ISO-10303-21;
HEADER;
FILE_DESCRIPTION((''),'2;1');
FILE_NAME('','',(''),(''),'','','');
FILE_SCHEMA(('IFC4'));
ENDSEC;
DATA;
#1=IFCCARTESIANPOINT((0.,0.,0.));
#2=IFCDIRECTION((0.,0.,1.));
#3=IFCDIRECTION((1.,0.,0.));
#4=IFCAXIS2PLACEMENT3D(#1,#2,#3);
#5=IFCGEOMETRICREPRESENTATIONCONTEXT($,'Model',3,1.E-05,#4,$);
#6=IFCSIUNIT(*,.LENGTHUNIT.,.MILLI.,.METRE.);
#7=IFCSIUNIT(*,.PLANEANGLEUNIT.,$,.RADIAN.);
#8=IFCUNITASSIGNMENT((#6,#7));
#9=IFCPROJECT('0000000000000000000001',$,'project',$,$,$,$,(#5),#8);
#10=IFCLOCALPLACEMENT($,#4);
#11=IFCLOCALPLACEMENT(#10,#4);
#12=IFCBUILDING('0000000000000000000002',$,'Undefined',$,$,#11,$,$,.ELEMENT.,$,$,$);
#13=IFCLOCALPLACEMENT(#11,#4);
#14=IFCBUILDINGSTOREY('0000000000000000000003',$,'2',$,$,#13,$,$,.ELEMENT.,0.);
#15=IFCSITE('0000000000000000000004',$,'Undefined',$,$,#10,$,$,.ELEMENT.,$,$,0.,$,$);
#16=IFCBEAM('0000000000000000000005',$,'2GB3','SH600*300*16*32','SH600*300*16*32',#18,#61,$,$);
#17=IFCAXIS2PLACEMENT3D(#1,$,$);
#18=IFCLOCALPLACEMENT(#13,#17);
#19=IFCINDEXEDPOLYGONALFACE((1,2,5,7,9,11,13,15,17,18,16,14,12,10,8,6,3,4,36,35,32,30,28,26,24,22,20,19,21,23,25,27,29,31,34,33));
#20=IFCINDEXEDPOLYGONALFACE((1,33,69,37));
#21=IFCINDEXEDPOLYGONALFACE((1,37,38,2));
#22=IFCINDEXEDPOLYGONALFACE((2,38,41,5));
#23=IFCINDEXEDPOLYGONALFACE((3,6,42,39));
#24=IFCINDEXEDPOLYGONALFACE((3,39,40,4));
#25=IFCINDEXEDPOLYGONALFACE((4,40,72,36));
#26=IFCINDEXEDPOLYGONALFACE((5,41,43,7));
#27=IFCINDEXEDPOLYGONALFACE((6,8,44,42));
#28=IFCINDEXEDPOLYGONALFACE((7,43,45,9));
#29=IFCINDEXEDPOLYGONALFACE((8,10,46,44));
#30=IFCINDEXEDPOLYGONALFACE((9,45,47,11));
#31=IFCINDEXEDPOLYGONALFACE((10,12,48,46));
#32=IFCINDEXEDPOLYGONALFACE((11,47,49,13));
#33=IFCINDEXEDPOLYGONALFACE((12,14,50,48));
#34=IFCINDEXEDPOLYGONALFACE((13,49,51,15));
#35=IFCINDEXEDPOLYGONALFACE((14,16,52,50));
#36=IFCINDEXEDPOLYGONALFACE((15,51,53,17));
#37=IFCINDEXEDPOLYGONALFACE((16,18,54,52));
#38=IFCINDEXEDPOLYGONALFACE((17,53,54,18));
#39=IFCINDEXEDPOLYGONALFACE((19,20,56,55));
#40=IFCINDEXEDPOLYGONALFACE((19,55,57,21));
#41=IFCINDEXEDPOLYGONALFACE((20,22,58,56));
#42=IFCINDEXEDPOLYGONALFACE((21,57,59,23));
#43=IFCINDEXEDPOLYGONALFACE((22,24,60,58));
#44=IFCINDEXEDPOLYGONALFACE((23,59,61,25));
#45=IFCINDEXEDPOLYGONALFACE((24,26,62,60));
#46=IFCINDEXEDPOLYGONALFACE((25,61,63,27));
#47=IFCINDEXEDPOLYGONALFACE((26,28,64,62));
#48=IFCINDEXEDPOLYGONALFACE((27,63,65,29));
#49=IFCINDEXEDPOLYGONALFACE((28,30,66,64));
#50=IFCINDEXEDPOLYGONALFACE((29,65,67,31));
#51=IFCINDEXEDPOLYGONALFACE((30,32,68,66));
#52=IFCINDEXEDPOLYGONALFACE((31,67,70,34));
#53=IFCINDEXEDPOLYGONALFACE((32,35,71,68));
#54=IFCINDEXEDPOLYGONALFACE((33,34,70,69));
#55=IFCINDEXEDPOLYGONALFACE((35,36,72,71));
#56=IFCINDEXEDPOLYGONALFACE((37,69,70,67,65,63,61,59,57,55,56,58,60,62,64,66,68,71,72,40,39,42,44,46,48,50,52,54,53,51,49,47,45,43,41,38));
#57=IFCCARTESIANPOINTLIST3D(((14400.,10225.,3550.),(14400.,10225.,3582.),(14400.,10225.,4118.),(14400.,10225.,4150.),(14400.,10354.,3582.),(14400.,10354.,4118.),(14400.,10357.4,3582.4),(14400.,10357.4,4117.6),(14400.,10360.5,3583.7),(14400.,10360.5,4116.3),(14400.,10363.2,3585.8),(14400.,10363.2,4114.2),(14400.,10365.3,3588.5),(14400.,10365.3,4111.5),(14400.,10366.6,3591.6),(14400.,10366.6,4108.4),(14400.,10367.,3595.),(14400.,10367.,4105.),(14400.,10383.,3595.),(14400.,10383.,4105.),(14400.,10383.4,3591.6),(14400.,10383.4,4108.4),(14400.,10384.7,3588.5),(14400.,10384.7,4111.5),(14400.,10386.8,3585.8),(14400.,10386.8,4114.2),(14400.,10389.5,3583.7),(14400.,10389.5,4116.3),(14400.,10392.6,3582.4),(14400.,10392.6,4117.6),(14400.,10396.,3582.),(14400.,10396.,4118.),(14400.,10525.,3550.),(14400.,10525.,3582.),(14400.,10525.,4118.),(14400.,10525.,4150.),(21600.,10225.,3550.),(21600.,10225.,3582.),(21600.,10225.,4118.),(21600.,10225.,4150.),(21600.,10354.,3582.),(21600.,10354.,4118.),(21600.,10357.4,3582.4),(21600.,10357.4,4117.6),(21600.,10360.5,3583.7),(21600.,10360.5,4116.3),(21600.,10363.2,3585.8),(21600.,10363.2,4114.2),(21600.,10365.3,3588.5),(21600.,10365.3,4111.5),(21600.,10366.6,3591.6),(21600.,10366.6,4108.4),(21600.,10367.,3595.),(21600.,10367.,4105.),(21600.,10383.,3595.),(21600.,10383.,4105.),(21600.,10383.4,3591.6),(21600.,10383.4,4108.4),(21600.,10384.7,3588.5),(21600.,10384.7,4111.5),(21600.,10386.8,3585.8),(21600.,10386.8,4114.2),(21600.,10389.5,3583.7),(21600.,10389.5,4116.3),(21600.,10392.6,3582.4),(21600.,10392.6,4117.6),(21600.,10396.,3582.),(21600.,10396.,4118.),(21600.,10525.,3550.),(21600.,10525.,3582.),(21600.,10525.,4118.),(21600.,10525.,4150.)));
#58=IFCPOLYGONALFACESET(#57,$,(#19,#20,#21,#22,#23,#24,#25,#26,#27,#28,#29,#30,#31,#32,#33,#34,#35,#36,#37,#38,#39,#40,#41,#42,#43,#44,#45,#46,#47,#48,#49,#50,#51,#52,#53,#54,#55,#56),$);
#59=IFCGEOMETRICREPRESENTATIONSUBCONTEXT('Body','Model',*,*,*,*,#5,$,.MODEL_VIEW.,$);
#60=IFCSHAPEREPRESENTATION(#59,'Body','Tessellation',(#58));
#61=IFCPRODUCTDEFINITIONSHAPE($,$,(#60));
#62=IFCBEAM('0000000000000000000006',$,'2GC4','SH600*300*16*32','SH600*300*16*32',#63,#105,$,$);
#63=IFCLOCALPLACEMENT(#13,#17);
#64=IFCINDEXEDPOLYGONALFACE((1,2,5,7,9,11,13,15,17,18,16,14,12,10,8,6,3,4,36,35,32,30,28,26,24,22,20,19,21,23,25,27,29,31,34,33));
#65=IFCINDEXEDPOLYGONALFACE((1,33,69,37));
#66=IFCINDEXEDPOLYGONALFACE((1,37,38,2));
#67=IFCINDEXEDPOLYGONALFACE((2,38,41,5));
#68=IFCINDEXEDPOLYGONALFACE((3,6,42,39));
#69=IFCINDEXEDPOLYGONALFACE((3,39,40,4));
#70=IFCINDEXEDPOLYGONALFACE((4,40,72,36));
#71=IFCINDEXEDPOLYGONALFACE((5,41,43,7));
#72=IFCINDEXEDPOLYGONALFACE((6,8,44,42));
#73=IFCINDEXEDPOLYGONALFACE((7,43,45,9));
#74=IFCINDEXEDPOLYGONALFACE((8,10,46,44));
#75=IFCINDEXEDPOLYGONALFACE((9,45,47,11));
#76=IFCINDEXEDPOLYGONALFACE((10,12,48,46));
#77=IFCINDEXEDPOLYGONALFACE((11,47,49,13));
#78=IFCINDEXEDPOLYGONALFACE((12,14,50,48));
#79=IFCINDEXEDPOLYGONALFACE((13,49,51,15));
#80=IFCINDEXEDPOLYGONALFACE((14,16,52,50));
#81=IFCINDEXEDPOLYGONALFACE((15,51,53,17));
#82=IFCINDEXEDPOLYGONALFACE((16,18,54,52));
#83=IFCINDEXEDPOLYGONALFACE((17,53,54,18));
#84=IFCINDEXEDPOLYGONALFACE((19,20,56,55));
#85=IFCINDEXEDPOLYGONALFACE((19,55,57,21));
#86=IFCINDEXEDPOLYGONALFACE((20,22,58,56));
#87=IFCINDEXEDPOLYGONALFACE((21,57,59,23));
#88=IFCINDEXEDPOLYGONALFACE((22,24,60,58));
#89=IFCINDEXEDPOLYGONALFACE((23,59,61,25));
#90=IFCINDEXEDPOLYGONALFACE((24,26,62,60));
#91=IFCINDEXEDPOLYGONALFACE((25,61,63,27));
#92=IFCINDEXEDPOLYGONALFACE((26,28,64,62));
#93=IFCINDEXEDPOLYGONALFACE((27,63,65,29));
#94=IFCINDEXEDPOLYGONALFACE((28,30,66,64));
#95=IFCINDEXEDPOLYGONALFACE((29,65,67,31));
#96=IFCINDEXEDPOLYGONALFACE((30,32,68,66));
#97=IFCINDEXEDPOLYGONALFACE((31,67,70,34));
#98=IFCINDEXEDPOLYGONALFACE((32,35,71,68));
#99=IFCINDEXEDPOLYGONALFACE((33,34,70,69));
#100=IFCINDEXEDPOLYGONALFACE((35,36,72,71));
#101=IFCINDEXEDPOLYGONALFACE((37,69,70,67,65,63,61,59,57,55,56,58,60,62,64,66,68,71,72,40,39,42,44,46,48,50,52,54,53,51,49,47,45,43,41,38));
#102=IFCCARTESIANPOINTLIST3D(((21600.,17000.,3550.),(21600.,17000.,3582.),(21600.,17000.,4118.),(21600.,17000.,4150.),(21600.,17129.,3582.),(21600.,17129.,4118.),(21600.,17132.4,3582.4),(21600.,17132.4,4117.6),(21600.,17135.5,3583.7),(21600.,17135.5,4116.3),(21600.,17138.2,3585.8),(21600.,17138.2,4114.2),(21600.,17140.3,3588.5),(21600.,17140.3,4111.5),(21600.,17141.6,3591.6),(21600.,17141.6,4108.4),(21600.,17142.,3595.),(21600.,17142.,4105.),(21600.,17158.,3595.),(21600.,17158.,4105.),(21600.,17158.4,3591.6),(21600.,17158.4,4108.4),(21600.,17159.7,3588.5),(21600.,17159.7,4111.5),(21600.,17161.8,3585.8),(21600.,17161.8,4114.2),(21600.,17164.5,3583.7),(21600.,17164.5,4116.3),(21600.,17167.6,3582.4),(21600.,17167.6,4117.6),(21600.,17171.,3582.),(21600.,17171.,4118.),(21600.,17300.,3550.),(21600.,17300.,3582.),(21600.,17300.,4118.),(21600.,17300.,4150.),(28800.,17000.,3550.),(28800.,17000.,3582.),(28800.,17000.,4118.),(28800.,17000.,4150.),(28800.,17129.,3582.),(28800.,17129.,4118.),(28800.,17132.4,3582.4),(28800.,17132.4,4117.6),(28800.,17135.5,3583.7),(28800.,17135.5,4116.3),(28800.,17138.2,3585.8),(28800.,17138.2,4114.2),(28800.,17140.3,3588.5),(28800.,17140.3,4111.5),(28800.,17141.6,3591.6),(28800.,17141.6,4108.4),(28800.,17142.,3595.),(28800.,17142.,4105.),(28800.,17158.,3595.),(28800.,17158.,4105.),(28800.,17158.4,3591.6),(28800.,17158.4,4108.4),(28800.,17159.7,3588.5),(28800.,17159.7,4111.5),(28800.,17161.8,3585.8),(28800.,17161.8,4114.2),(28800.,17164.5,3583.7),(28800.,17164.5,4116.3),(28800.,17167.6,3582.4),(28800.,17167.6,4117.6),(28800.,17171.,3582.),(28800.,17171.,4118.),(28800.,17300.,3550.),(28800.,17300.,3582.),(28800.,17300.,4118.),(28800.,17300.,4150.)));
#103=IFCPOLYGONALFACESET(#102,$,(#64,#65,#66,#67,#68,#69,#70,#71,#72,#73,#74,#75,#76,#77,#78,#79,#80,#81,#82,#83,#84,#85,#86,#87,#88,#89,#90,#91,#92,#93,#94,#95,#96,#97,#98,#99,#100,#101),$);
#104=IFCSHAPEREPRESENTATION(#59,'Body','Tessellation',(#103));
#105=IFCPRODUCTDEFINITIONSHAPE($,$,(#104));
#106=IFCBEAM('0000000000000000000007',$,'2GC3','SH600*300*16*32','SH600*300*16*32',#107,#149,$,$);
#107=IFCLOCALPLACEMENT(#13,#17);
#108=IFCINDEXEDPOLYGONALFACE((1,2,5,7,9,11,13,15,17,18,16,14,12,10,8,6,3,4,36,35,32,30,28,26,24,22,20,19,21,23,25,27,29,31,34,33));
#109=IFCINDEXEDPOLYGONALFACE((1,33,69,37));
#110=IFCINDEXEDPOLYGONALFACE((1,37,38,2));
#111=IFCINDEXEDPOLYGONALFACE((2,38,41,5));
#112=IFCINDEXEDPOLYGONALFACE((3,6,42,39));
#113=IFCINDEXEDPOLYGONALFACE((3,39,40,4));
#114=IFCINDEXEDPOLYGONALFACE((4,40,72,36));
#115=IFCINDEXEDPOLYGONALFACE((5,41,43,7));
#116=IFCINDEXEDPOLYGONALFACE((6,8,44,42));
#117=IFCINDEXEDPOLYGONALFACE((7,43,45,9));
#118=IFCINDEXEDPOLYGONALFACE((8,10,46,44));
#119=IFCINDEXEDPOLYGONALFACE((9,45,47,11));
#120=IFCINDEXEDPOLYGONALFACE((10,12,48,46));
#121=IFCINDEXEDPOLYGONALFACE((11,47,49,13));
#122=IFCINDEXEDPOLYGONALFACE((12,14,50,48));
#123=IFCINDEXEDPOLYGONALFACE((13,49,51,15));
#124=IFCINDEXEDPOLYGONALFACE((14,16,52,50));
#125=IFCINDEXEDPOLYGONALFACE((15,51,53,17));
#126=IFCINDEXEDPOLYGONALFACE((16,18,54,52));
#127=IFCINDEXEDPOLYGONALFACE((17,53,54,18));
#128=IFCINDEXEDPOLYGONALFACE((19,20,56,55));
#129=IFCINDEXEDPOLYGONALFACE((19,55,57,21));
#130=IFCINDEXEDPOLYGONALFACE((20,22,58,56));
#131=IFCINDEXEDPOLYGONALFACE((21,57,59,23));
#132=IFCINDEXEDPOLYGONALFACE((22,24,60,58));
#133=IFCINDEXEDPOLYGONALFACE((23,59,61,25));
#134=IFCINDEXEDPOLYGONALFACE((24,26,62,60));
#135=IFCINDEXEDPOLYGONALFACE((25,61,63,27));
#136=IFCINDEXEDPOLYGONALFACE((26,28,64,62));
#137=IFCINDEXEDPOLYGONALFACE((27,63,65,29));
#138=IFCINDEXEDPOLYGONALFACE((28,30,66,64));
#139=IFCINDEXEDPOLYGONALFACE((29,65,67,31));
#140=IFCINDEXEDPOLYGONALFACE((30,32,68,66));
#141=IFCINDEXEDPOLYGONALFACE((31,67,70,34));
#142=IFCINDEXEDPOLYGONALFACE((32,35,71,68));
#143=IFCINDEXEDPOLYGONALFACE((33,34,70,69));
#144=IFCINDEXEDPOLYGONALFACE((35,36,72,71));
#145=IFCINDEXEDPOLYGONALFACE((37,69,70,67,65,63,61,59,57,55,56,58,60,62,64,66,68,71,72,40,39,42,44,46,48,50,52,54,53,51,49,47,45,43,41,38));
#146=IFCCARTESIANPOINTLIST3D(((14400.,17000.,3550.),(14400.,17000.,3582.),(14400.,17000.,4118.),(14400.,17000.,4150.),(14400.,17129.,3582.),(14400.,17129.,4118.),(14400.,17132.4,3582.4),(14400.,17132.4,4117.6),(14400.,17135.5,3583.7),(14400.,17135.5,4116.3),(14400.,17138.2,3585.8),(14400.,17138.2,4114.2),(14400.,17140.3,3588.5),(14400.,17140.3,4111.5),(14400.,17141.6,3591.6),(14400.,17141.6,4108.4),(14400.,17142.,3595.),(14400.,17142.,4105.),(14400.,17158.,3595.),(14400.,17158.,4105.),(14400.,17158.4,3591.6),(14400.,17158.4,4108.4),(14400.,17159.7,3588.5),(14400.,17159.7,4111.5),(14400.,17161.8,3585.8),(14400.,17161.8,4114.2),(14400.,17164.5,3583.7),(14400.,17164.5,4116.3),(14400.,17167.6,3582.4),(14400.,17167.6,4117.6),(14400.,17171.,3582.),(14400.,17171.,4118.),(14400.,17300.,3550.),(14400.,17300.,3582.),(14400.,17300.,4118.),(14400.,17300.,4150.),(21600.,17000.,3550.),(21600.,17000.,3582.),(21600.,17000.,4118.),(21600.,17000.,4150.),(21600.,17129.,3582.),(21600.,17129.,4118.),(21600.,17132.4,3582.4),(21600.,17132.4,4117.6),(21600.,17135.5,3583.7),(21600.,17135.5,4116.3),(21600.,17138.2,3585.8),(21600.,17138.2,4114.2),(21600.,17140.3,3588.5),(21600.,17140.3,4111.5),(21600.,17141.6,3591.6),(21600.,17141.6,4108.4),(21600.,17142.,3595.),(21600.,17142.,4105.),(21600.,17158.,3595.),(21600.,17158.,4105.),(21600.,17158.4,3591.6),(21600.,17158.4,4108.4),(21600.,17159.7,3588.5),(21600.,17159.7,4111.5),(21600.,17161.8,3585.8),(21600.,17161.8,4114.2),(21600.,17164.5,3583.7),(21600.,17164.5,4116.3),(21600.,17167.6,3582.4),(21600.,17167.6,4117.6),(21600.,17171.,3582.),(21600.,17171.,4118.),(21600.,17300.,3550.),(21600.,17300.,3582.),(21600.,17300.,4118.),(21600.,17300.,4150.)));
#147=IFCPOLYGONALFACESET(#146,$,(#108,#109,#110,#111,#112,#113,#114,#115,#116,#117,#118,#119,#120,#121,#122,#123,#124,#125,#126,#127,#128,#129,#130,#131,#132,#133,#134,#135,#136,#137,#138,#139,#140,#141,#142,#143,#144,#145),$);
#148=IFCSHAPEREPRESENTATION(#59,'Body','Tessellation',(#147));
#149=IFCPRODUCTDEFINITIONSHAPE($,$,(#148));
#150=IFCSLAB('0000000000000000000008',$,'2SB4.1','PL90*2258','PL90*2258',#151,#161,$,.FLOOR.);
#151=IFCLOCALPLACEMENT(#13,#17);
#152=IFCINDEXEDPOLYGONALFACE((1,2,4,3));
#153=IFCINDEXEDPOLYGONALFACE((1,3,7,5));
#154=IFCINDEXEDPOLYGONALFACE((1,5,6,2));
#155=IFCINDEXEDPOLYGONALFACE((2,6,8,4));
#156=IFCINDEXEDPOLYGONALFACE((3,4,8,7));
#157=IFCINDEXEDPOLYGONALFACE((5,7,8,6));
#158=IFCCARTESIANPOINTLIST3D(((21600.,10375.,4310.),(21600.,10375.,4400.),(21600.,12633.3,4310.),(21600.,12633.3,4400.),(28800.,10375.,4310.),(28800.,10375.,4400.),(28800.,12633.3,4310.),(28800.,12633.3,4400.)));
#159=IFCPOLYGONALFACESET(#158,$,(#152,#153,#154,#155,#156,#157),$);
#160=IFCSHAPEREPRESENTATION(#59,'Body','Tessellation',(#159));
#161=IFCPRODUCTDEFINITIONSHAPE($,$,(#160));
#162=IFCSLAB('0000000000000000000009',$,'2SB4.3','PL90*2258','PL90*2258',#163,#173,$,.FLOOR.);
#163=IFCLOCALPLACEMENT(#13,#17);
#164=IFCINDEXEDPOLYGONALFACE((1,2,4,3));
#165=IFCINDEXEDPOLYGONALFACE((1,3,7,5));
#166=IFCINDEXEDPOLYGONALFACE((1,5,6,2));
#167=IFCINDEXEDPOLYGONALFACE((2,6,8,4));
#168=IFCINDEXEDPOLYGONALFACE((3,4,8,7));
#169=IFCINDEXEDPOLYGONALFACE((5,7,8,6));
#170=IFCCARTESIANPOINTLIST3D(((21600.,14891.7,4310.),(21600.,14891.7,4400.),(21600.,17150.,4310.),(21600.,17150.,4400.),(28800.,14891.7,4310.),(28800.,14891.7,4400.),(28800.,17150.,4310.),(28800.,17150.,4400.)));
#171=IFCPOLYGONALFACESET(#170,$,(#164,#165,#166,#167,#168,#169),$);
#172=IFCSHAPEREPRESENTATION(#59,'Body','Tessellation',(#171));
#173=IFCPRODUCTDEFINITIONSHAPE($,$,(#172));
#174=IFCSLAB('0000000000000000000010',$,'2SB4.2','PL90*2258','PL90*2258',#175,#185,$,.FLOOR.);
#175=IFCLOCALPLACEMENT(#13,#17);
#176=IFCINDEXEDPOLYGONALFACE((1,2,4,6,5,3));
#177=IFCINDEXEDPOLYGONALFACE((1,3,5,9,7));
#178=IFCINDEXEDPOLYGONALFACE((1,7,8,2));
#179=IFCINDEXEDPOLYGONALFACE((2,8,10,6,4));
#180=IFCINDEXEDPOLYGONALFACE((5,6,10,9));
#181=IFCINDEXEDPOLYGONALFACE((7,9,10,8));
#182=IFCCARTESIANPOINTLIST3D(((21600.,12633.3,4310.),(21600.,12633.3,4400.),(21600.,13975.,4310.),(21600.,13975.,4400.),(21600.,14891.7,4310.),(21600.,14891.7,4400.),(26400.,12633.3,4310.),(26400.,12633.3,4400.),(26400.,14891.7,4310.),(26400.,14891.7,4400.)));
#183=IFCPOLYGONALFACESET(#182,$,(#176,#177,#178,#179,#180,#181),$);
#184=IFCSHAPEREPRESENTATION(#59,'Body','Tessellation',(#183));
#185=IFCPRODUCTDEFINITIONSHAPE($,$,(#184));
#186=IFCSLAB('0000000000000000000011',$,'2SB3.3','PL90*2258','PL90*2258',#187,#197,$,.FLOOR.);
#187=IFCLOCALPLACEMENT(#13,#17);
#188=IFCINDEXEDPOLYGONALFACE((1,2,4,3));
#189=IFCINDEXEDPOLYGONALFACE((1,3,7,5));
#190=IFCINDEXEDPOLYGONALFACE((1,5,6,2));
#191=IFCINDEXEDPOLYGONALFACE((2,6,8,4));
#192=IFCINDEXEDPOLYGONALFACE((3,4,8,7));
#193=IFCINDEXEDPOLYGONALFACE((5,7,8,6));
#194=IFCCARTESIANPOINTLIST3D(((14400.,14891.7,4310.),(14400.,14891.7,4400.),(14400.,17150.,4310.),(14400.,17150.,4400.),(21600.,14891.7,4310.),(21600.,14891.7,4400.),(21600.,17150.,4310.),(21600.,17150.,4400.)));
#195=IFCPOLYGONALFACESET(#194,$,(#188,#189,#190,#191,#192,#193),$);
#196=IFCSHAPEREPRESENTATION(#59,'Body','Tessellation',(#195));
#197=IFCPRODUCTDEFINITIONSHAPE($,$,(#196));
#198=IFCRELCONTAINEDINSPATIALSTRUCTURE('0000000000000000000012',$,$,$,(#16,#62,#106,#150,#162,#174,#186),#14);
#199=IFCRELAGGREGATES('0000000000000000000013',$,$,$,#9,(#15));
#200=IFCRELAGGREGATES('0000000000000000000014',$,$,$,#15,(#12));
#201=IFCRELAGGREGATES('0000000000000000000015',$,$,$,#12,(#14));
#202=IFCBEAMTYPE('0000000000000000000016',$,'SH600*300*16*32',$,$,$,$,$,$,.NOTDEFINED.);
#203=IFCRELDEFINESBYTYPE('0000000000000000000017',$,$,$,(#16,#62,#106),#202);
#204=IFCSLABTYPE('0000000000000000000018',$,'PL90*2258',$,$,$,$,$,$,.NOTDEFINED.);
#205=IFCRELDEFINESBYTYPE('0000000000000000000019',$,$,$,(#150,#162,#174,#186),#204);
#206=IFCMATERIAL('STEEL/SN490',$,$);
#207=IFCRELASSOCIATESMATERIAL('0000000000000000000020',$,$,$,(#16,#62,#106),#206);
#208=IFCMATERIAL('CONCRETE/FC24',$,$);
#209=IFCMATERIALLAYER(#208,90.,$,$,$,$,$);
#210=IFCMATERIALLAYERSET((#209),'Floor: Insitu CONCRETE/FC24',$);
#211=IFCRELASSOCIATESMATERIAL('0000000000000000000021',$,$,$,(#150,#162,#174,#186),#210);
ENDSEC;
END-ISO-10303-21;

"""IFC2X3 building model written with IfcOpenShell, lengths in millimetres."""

from ifc_helpers import new_model, si_unit, frame, origin_with_axes, origin_2d_with_axis, place, context, subcontext, project, spatial, polyline, i_section, outline, extrude, material, layer, layer_set, layer_usage, type_object, element, save


model = new_model("IFC2X3")

# Units and contexts
model_context = context("Model", 3, precision=1e-05, world=origin_with_axes())
body_context = subcontext(model_context, "Body", "Model", "MODEL_VIEW")
ifc_project = project(units=[si_unit("LENGTHUNIT", "METRE", prefix="MILLI"), si_unit("PLANEANGLEUNIT", "RADIAN")], contexts=[model_context])

# Site, building, storey
site_placement = place(None, origin_with_axes())
site = spatial("IfcSite", under=ifc_project, at=site_placement, Name="Undefined", CompositionType="ELEMENT", RefElevation=0.0)
building_placement = place(site_placement, origin_with_axes())
building = spatial("IfcBuilding", under=site, at=building_placement, Name="Undefined", CompositionType="ELEMENT")
storey_placement = place(building_placement, origin_with_axes())
storey = spatial("IfcBuildingStorey", under=building, at=storey_placement, Name="2", CompositionType="ELEMENT", Elevation=0.0)

# Shared definitions
ifc_material_1 = material(Name="STEEL/SN490")

# Beams
beam_type_1 = type_object("IfcBeamType", Name="SH600*300*16*32", PredefinedType="NOTDEFINED")
for number, where, z_axis, x_axis, name in (
    (1, (14400.0, 10375.0, 3850.0), (0.0, 0.0, 1.0), (1.0, 0.0, 0.0), "2GB3"),
    (2, (21600.0, 17150.0, 3850.0), (0.0, 0.0, 1.0), (1.0, 0.0, 0.0), "2GC4"),
    (3, (14400.0, 17150.0, 3850.0), (0.0, 0.0, 1.0), (1.0, 0.0, 0.0), "2GC3"),
):
    element("IfcBeam", number, at=place(storey_placement, frame(where, z_axis=z_axis, x_axis=x_axis)), inside=storey, type_object=beam_type_1, material=ifc_material_1, Name=name, Description="SH600*300*16*32", ObjectType="SH600*300*16*32", context=body_context, shape_type="SweptSolid", body=[
        extrude(i_section(OverallWidth=300.0, OverallDepth=600.0, WebThickness=16.0, FlangeThickness=32.0, FilletRadius=13.0, at=origin_2d_with_axis()), frame((7200.0, 0.0, 0.0), z_axis=(-1.0, 0.0, 0.0), x_axis=(0.0, -1.0, 0.0)), (0.0, 0.0, 1.0), 7200.0),
    ])

# Slabs
ifc_material_2 = material(Name="CONCRETE/FC24")
ifc_layer = layer(ifc_material_2, 90.0)
ifc_layer_set = layer_set([ifc_layer], Name="Floor: Insitu CONCRETE/FC24")
ifc_layer_usage_1 = layer_usage(ifc_layer_set, "AXIS3", "POSITIVE", -45.0)
slab_type_1 = type_object("IfcSlabType", Name="PL90*2258", PredefinedType="NOTDEFINED")
slab_1_placement = place(storey_placement, frame((21600.0, 10375.0, 4355.0), z_axis=(0.0, 0.0, 1.0), x_axis=(1.0, 0.0, 0.0)))
element("IfcSlab", 4, at=slab_1_placement, inside=storey, type_object=slab_type_1, material=ifc_layer_usage_1, Name="2SB4.1", Description="PL90*2258", ObjectType="PL90*2258", PredefinedType="FLOOR", context=body_context, shape_type="SweptSolid", body=[
    extrude(outline(polyline([(0.0, 0.0), (7200.0, 0.0), (7200.0, 2258.3), (0.0, 2258.3), (0.0, 0.0)])), frame((0.0, 0.0, -45.0), z_axis=(0.0, 0.0, 1.0), x_axis=(1.0, 0.0, 0.0)), (0.0, 0.0, 1.0), 90.0),
])
ifc_layer_usage_2 = layer_usage(ifc_layer_set, "AXIS3", "POSITIVE", -45.0)
slab_2_placement = place(storey_placement, frame((21600.0, 14891.7, 4355.0), z_axis=(0.0, 0.0, 1.0), x_axis=(1.0, 0.0, 0.0)))
element("IfcSlab", 5, at=slab_2_placement, inside=storey, type_object=slab_type_1, material=ifc_layer_usage_2, Name="2SB4.3", Description="PL90*2258", ObjectType="PL90*2258", PredefinedType="FLOOR", context=body_context, shape_type="SweptSolid", body=[
    extrude(outline(polyline([(0.0, 0.0), (7200.0, 0.0), (7200.0, 2258.3), (0.0, 2258.3), (0.0, 0.0)])), frame((0.0, 0.0, -45.0), z_axis=(0.0, 0.0, 1.0), x_axis=(1.0, 0.0, 0.0)), (0.0, 0.0, 1.0), 90.0),
])
ifc_layer_usage_3 = layer_usage(ifc_layer_set, "AXIS3", "POSITIVE", -45.0)
slab_3_placement = place(storey_placement, frame((21600.0, 12633.3, 4355.0), z_axis=(0.0, 0.0, 1.0), x_axis=(1.0, 0.0, 0.0)))
element("IfcSlab", 6, at=slab_3_placement, inside=storey, type_object=slab_type_1, material=ifc_layer_usage_3, Name="2SB4.2", Description="PL90*2258", ObjectType="PL90*2258", PredefinedType="FLOOR", context=body_context, shape_type="SweptSolid", body=[
    extrude(outline(polyline([(0.0, 0.0), (4800.0, 0.0), (4800.0, 2258.4), (0.0, 2258.4), (0.0, 1341.7), (0.0, 0.0)])), frame((0.0, 0.0, -45.0), z_axis=(0.0, 0.0, 1.0), x_axis=(1.0, 0.0, 0.0)), (0.0, 0.0, 1.0), 90.0),
])
ifc_layer_usage_4 = layer_usage(ifc_layer_set, "AXIS3", "POSITIVE", -45.0)
slab_4_placement = place(storey_placement, frame((14400.0, 14891.7, 4355.0), z_axis=(0.0, 0.0, 1.0), x_axis=(1.0, 0.0, 0.0)))
element("IfcSlab", 7, at=slab_4_placement, inside=storey, type_object=slab_type_1, material=ifc_layer_usage_4, Name="2SB3.3", Description="PL90*2258", ObjectType="PL90*2258", PredefinedType="FLOOR", context=body_context, shape_type="SweptSolid", body=[
    extrude(outline(polyline([(0.0, 0.0), (7200.0, 0.0), (7200.0, 2258.3), (0.0, 2258.3), (0.0, 0.0)])), frame((0.0, 0.0, -45.0), z_axis=(0.0, 0.0, 1.0), x_axis=(1.0, 0.0, 0.0)), (0.0, 0.0, 1.0), 90.0),
])

save(model, "model.ifc")
